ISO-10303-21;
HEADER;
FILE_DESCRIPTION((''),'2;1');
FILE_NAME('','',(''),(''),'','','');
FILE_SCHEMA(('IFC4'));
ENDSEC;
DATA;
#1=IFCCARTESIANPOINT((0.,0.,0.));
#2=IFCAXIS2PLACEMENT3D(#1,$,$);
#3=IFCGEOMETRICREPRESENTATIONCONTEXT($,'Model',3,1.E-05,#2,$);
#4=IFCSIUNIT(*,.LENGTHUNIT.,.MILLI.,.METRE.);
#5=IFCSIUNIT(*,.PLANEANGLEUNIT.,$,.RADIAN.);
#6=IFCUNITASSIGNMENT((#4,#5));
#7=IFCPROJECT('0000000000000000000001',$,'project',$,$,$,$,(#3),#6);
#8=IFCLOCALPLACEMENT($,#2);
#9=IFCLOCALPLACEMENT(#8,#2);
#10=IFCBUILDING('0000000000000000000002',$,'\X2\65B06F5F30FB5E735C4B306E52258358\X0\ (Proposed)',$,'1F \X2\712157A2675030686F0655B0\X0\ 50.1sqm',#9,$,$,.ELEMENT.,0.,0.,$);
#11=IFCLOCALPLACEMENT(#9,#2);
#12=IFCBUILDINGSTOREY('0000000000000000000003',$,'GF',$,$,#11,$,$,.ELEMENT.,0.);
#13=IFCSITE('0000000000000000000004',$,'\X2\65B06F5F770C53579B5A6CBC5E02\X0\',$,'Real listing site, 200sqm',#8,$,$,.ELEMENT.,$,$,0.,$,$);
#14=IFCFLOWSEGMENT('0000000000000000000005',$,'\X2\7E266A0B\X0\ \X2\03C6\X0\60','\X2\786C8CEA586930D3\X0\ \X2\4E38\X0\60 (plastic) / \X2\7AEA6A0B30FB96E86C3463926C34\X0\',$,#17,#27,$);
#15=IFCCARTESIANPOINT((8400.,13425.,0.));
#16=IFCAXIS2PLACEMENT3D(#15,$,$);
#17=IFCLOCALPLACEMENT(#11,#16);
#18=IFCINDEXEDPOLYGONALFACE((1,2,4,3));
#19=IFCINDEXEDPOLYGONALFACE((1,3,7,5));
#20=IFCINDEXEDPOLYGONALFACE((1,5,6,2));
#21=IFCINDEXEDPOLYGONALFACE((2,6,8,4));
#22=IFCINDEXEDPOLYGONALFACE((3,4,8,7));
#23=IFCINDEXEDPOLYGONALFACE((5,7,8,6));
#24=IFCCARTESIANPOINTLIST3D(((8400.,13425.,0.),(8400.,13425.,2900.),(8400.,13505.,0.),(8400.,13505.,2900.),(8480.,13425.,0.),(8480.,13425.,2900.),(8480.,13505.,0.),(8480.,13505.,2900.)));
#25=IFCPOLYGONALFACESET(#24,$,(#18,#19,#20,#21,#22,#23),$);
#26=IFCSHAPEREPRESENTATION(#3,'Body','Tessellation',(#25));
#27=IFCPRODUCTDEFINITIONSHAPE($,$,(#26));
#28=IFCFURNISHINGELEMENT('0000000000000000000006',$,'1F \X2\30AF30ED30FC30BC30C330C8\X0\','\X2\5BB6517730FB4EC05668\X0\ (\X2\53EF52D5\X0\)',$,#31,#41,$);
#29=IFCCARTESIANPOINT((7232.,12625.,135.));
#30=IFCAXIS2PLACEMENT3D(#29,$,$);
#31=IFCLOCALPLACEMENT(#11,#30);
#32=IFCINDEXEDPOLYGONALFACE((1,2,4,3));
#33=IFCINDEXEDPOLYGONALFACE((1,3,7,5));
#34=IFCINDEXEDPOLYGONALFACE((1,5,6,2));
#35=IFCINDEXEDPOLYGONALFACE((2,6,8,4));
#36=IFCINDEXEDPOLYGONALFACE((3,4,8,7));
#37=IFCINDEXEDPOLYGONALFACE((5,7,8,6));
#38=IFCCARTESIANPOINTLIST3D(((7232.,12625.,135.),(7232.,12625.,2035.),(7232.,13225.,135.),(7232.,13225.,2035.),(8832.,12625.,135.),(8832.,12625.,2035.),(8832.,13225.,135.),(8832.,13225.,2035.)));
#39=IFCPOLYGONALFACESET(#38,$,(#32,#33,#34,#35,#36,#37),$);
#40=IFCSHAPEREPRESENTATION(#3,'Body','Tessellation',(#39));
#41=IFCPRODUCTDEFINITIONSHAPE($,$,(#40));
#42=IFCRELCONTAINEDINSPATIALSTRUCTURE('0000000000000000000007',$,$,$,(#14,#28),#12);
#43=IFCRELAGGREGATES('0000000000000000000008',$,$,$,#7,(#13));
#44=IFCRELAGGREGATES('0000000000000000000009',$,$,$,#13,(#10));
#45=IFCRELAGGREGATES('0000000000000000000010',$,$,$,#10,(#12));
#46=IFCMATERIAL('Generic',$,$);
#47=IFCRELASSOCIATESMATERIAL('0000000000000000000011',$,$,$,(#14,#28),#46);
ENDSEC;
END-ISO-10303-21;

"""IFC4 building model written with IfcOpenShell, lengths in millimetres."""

from ifc_helpers import new_model, si_unit, frame, frame_2d, origin, place, context, project, spatial, rectangle, extrude, material, element, save


model = new_model("IFC4")

# Units and contexts
model_context = context("Model", 3, precision=1e-05, world=origin())
ifc_project = project(units=[si_unit("LENGTHUNIT", "METRE", prefix="MILLI"), si_unit("PLANEANGLEUNIT", "RADIAN")], contexts=[model_context])

# Site, building, storey
site_placement = place(None, origin())
site = spatial("IfcSite", under=ifc_project, at=site_placement, Name="新潟県南魚沼市", ObjectType="Real listing site, 200sqm", CompositionType="ELEMENT", RefElevation=0.0)
building_placement = place(site_placement, origin())
building = spatial("IfcBuilding", under=site, at=building_placement, Name="新潟・平屋の別荘 (Proposed)", ObjectType="1F 無垢材と漆喰 50.1sqm", CompositionType="ELEMENT", ElevationOfRefHeight=0.0, ElevationOfTerrain=0.0)
storey_placement = place(building_placement, origin())
storey = spatial("IfcBuildingStorey", under=building, at=storey_placement, Name="GF", CompositionType="ELEMENT", Elevation=0.0)

# Shared definitions
ifc_material_1 = material(Name="Generic")

# Flow segment
flow_segment_placement = place(storey_placement, frame((8400.0, 13425.0, 0.0)))
element("IfcFlowSegment", 1, at=flow_segment_placement, inside=storey, material=ifc_material_1, Name="縦樋 φ60", Description="硬質塩ビ 丸60 (plastic) / 竪樋・雨水排水", context=model_context, shape_type="SweptSolid", body=[
    extrude(rectangle(XDim=80.0, YDim=80.0, at=frame_2d((40.0, 40.0))), frame((8400.0, 13425.0, 0.0)), (0.0, 0.0, 1.0), 2900.0),
])

# Furnishing element
furnishing_placement = place(storey_placement, frame((7232.0, 12625.0, 135.0)))
element("IfcFurnishingElement", 2, at=furnishing_placement, inside=storey, material=ifc_material_1, Name="1F クローゼット", Description="家具・什器 (可動)", context=model_context, shape_type="SweptSolid", body=[
    extrude(rectangle(XDim=1600.0, YDim=600.0, at=frame_2d((800.0, 300.0))), frame((7232.0, 12625.0, 135.0)), (0.0, 0.0, 1.0), 1900.0),
])

save(model, "model.ifc")
